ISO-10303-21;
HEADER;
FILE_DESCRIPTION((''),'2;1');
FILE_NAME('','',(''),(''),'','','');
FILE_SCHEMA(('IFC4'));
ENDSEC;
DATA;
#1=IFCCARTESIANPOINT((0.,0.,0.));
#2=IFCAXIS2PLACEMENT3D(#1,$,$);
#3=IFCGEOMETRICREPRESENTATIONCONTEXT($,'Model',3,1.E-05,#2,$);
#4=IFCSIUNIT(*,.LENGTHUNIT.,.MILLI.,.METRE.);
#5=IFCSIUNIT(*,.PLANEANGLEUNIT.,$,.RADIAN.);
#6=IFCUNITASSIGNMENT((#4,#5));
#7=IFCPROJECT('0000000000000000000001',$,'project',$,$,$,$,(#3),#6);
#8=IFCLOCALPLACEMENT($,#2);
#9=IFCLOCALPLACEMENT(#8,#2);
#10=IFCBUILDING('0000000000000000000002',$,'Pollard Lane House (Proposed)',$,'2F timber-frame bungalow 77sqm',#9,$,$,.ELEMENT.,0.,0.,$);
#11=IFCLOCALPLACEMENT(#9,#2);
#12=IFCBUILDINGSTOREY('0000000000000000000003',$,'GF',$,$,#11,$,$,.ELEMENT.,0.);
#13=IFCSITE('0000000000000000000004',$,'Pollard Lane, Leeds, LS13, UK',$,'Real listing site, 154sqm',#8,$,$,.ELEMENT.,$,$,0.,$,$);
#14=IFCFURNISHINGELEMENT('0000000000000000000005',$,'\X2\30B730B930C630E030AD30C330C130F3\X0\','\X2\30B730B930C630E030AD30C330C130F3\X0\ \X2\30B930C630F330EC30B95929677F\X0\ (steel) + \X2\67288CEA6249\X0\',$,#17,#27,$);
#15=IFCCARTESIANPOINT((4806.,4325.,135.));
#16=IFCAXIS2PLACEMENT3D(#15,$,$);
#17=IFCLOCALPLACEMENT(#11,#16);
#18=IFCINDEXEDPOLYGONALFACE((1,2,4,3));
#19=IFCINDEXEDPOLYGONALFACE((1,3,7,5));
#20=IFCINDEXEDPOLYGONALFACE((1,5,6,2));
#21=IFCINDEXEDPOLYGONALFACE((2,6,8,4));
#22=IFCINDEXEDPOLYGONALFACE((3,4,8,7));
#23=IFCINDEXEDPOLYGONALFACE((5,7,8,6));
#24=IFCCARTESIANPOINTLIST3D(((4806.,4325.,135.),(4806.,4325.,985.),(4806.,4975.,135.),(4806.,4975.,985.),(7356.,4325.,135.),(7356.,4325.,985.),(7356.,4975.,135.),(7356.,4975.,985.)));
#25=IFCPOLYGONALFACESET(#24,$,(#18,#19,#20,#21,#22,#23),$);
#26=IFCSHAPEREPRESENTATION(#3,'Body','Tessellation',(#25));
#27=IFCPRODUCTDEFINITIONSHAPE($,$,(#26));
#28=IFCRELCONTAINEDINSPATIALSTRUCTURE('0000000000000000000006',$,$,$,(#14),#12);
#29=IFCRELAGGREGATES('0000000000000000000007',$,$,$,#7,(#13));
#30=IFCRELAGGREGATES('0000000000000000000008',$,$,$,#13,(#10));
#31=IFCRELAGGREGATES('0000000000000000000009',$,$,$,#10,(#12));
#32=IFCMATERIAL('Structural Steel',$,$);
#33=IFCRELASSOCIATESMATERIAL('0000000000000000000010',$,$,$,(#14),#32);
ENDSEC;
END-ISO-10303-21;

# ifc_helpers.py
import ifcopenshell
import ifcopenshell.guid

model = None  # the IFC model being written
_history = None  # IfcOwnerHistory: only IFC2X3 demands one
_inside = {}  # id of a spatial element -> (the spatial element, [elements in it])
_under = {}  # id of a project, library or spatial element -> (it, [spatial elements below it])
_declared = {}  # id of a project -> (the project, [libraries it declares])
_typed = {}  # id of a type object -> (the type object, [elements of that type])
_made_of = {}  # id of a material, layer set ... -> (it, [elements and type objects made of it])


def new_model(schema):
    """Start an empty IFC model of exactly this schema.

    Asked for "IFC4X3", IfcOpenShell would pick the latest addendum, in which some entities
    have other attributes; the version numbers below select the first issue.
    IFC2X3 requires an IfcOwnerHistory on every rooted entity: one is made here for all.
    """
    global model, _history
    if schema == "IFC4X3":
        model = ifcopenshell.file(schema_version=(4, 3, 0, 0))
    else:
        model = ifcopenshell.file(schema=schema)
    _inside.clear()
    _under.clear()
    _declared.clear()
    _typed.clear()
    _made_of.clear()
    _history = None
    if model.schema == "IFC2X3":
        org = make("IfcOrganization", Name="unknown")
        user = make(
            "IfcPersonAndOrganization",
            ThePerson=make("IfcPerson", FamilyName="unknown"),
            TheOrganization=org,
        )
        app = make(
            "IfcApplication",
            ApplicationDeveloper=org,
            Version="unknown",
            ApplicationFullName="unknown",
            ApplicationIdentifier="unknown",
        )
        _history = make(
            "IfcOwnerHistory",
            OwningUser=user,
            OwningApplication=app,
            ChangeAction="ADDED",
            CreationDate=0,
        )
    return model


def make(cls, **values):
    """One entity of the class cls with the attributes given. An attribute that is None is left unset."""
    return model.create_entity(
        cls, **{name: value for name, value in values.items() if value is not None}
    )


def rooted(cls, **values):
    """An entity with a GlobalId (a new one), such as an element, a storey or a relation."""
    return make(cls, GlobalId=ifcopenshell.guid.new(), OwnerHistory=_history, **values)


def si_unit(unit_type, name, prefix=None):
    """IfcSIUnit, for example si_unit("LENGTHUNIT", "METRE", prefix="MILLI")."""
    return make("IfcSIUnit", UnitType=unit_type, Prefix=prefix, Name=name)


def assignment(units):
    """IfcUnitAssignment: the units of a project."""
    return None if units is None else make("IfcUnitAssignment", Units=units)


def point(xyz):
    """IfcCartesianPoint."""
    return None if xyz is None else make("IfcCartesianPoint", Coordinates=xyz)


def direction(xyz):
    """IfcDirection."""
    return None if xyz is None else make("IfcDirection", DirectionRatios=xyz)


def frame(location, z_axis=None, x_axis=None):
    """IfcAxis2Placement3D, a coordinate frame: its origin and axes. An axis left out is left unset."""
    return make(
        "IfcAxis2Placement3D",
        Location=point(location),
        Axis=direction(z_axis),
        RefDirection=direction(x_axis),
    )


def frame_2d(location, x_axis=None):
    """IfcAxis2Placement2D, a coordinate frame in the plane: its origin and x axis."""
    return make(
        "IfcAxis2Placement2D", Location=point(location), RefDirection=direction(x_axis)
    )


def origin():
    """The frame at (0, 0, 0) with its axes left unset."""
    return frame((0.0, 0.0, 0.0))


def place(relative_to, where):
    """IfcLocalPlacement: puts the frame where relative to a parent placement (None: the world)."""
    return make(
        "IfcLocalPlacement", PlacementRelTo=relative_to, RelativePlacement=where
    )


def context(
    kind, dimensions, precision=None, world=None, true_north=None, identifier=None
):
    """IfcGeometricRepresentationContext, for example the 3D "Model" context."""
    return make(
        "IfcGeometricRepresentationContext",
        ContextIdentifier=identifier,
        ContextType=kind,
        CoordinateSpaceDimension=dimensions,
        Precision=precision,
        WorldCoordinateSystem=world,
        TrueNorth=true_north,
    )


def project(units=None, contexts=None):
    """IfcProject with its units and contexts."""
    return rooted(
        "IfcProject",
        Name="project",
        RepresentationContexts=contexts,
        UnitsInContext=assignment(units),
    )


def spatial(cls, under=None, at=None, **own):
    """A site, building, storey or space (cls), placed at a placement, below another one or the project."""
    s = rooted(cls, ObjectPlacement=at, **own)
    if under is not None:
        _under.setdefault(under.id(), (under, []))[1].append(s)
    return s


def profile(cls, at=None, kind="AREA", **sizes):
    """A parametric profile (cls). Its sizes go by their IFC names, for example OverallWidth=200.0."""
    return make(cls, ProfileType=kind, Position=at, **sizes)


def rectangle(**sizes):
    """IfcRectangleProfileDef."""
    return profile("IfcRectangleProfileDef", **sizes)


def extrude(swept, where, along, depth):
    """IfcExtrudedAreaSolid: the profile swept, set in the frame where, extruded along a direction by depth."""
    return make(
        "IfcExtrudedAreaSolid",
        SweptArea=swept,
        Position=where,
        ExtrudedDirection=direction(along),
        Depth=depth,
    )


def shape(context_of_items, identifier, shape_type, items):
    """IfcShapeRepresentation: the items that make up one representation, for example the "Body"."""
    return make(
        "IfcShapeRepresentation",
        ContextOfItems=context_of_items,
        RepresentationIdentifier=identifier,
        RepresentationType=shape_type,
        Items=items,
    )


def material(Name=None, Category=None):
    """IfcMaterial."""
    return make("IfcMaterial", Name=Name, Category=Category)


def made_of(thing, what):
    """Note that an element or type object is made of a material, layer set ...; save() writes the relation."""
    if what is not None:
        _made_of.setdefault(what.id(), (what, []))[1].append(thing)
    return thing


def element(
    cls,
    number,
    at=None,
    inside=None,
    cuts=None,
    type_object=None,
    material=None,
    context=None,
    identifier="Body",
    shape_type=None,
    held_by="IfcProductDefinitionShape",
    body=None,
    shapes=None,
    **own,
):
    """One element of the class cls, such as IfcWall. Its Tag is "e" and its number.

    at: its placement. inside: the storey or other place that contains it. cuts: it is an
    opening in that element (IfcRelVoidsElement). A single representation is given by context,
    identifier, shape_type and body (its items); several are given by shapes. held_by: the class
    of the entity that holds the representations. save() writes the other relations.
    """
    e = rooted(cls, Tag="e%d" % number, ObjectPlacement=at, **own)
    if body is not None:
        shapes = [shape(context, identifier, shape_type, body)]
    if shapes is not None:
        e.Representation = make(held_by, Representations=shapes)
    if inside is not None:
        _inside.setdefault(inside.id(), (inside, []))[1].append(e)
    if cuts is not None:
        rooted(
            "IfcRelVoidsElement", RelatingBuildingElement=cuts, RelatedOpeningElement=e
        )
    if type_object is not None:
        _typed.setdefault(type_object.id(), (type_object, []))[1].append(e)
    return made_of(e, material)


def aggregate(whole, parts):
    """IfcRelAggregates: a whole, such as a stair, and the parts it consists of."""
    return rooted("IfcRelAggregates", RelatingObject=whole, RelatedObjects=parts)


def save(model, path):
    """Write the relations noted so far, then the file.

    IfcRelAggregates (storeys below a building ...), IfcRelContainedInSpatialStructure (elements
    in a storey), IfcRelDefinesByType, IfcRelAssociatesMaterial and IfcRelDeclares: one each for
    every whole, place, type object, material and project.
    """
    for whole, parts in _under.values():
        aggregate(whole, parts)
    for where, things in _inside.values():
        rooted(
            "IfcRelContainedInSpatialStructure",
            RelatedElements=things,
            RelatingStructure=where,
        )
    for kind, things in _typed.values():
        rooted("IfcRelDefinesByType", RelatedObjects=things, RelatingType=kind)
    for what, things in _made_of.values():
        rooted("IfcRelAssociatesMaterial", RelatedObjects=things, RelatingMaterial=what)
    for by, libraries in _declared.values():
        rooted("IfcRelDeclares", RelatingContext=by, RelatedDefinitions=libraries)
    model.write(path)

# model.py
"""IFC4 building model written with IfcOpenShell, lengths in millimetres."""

from ifc_helpers import new_model, si_unit, frame, frame_2d, origin, place, context, project, spatial, rectangle, extrude, material, element, save


model = new_model("IFC4")

# Units and contexts
model_context = context("Model", 3, precision=1e-05, world=origin())
ifc_project = project(units=[si_unit("LENGTHUNIT", "METRE", prefix="MILLI"), si_unit("PLANEANGLEUNIT", "RADIAN")], contexts=[model_context])

# Site, building, storey
site_placement = place(None, origin())
site = spatial("IfcSite", under=ifc_project, at=site_placement, Name="Pollard Lane, Leeds, LS13, UK", ObjectType="Real listing site, 154sqm", CompositionType="ELEMENT", RefElevation=0.0)
building_placement = place(site_placement, origin())
building = spatial("IfcBuilding", under=site, at=building_placement, Name="Pollard Lane House (Proposed)", ObjectType="2F timber-frame bungalow 77sqm", CompositionType="ELEMENT", ElevationOfRefHeight=0.0, ElevationOfTerrain=0.0)
storey_placement = place(building_placement, origin())
storey = spatial("IfcBuildingStorey", under=building, at=storey_placement, Name="GF", CompositionType="ELEMENT", Elevation=0.0)

# Furnishing element
ifc_material_1 = material(Name="Structural Steel")
furnishing_1_placement = place(storey_placement, frame((4806.0, 4325.0, 135.0)))
element("IfcFurnishingElement", 1, at=furnishing_1_placement, inside=storey, material=ifc_material_1, Name="システムキッチン", Description="システムキッチン ステンレス天板 (steel) + 木質扉", context=model_context, shape_type="SweptSolid", body=[
    extrude(rectangle(XDim=2550.0, YDim=650.0, at=frame_2d((1275.0, 325.0))), frame((4806.0, 4325.0, 135.0)), (0.0, 0.0, 1.0), 850.0),
])

save(model, "model.ifc")
